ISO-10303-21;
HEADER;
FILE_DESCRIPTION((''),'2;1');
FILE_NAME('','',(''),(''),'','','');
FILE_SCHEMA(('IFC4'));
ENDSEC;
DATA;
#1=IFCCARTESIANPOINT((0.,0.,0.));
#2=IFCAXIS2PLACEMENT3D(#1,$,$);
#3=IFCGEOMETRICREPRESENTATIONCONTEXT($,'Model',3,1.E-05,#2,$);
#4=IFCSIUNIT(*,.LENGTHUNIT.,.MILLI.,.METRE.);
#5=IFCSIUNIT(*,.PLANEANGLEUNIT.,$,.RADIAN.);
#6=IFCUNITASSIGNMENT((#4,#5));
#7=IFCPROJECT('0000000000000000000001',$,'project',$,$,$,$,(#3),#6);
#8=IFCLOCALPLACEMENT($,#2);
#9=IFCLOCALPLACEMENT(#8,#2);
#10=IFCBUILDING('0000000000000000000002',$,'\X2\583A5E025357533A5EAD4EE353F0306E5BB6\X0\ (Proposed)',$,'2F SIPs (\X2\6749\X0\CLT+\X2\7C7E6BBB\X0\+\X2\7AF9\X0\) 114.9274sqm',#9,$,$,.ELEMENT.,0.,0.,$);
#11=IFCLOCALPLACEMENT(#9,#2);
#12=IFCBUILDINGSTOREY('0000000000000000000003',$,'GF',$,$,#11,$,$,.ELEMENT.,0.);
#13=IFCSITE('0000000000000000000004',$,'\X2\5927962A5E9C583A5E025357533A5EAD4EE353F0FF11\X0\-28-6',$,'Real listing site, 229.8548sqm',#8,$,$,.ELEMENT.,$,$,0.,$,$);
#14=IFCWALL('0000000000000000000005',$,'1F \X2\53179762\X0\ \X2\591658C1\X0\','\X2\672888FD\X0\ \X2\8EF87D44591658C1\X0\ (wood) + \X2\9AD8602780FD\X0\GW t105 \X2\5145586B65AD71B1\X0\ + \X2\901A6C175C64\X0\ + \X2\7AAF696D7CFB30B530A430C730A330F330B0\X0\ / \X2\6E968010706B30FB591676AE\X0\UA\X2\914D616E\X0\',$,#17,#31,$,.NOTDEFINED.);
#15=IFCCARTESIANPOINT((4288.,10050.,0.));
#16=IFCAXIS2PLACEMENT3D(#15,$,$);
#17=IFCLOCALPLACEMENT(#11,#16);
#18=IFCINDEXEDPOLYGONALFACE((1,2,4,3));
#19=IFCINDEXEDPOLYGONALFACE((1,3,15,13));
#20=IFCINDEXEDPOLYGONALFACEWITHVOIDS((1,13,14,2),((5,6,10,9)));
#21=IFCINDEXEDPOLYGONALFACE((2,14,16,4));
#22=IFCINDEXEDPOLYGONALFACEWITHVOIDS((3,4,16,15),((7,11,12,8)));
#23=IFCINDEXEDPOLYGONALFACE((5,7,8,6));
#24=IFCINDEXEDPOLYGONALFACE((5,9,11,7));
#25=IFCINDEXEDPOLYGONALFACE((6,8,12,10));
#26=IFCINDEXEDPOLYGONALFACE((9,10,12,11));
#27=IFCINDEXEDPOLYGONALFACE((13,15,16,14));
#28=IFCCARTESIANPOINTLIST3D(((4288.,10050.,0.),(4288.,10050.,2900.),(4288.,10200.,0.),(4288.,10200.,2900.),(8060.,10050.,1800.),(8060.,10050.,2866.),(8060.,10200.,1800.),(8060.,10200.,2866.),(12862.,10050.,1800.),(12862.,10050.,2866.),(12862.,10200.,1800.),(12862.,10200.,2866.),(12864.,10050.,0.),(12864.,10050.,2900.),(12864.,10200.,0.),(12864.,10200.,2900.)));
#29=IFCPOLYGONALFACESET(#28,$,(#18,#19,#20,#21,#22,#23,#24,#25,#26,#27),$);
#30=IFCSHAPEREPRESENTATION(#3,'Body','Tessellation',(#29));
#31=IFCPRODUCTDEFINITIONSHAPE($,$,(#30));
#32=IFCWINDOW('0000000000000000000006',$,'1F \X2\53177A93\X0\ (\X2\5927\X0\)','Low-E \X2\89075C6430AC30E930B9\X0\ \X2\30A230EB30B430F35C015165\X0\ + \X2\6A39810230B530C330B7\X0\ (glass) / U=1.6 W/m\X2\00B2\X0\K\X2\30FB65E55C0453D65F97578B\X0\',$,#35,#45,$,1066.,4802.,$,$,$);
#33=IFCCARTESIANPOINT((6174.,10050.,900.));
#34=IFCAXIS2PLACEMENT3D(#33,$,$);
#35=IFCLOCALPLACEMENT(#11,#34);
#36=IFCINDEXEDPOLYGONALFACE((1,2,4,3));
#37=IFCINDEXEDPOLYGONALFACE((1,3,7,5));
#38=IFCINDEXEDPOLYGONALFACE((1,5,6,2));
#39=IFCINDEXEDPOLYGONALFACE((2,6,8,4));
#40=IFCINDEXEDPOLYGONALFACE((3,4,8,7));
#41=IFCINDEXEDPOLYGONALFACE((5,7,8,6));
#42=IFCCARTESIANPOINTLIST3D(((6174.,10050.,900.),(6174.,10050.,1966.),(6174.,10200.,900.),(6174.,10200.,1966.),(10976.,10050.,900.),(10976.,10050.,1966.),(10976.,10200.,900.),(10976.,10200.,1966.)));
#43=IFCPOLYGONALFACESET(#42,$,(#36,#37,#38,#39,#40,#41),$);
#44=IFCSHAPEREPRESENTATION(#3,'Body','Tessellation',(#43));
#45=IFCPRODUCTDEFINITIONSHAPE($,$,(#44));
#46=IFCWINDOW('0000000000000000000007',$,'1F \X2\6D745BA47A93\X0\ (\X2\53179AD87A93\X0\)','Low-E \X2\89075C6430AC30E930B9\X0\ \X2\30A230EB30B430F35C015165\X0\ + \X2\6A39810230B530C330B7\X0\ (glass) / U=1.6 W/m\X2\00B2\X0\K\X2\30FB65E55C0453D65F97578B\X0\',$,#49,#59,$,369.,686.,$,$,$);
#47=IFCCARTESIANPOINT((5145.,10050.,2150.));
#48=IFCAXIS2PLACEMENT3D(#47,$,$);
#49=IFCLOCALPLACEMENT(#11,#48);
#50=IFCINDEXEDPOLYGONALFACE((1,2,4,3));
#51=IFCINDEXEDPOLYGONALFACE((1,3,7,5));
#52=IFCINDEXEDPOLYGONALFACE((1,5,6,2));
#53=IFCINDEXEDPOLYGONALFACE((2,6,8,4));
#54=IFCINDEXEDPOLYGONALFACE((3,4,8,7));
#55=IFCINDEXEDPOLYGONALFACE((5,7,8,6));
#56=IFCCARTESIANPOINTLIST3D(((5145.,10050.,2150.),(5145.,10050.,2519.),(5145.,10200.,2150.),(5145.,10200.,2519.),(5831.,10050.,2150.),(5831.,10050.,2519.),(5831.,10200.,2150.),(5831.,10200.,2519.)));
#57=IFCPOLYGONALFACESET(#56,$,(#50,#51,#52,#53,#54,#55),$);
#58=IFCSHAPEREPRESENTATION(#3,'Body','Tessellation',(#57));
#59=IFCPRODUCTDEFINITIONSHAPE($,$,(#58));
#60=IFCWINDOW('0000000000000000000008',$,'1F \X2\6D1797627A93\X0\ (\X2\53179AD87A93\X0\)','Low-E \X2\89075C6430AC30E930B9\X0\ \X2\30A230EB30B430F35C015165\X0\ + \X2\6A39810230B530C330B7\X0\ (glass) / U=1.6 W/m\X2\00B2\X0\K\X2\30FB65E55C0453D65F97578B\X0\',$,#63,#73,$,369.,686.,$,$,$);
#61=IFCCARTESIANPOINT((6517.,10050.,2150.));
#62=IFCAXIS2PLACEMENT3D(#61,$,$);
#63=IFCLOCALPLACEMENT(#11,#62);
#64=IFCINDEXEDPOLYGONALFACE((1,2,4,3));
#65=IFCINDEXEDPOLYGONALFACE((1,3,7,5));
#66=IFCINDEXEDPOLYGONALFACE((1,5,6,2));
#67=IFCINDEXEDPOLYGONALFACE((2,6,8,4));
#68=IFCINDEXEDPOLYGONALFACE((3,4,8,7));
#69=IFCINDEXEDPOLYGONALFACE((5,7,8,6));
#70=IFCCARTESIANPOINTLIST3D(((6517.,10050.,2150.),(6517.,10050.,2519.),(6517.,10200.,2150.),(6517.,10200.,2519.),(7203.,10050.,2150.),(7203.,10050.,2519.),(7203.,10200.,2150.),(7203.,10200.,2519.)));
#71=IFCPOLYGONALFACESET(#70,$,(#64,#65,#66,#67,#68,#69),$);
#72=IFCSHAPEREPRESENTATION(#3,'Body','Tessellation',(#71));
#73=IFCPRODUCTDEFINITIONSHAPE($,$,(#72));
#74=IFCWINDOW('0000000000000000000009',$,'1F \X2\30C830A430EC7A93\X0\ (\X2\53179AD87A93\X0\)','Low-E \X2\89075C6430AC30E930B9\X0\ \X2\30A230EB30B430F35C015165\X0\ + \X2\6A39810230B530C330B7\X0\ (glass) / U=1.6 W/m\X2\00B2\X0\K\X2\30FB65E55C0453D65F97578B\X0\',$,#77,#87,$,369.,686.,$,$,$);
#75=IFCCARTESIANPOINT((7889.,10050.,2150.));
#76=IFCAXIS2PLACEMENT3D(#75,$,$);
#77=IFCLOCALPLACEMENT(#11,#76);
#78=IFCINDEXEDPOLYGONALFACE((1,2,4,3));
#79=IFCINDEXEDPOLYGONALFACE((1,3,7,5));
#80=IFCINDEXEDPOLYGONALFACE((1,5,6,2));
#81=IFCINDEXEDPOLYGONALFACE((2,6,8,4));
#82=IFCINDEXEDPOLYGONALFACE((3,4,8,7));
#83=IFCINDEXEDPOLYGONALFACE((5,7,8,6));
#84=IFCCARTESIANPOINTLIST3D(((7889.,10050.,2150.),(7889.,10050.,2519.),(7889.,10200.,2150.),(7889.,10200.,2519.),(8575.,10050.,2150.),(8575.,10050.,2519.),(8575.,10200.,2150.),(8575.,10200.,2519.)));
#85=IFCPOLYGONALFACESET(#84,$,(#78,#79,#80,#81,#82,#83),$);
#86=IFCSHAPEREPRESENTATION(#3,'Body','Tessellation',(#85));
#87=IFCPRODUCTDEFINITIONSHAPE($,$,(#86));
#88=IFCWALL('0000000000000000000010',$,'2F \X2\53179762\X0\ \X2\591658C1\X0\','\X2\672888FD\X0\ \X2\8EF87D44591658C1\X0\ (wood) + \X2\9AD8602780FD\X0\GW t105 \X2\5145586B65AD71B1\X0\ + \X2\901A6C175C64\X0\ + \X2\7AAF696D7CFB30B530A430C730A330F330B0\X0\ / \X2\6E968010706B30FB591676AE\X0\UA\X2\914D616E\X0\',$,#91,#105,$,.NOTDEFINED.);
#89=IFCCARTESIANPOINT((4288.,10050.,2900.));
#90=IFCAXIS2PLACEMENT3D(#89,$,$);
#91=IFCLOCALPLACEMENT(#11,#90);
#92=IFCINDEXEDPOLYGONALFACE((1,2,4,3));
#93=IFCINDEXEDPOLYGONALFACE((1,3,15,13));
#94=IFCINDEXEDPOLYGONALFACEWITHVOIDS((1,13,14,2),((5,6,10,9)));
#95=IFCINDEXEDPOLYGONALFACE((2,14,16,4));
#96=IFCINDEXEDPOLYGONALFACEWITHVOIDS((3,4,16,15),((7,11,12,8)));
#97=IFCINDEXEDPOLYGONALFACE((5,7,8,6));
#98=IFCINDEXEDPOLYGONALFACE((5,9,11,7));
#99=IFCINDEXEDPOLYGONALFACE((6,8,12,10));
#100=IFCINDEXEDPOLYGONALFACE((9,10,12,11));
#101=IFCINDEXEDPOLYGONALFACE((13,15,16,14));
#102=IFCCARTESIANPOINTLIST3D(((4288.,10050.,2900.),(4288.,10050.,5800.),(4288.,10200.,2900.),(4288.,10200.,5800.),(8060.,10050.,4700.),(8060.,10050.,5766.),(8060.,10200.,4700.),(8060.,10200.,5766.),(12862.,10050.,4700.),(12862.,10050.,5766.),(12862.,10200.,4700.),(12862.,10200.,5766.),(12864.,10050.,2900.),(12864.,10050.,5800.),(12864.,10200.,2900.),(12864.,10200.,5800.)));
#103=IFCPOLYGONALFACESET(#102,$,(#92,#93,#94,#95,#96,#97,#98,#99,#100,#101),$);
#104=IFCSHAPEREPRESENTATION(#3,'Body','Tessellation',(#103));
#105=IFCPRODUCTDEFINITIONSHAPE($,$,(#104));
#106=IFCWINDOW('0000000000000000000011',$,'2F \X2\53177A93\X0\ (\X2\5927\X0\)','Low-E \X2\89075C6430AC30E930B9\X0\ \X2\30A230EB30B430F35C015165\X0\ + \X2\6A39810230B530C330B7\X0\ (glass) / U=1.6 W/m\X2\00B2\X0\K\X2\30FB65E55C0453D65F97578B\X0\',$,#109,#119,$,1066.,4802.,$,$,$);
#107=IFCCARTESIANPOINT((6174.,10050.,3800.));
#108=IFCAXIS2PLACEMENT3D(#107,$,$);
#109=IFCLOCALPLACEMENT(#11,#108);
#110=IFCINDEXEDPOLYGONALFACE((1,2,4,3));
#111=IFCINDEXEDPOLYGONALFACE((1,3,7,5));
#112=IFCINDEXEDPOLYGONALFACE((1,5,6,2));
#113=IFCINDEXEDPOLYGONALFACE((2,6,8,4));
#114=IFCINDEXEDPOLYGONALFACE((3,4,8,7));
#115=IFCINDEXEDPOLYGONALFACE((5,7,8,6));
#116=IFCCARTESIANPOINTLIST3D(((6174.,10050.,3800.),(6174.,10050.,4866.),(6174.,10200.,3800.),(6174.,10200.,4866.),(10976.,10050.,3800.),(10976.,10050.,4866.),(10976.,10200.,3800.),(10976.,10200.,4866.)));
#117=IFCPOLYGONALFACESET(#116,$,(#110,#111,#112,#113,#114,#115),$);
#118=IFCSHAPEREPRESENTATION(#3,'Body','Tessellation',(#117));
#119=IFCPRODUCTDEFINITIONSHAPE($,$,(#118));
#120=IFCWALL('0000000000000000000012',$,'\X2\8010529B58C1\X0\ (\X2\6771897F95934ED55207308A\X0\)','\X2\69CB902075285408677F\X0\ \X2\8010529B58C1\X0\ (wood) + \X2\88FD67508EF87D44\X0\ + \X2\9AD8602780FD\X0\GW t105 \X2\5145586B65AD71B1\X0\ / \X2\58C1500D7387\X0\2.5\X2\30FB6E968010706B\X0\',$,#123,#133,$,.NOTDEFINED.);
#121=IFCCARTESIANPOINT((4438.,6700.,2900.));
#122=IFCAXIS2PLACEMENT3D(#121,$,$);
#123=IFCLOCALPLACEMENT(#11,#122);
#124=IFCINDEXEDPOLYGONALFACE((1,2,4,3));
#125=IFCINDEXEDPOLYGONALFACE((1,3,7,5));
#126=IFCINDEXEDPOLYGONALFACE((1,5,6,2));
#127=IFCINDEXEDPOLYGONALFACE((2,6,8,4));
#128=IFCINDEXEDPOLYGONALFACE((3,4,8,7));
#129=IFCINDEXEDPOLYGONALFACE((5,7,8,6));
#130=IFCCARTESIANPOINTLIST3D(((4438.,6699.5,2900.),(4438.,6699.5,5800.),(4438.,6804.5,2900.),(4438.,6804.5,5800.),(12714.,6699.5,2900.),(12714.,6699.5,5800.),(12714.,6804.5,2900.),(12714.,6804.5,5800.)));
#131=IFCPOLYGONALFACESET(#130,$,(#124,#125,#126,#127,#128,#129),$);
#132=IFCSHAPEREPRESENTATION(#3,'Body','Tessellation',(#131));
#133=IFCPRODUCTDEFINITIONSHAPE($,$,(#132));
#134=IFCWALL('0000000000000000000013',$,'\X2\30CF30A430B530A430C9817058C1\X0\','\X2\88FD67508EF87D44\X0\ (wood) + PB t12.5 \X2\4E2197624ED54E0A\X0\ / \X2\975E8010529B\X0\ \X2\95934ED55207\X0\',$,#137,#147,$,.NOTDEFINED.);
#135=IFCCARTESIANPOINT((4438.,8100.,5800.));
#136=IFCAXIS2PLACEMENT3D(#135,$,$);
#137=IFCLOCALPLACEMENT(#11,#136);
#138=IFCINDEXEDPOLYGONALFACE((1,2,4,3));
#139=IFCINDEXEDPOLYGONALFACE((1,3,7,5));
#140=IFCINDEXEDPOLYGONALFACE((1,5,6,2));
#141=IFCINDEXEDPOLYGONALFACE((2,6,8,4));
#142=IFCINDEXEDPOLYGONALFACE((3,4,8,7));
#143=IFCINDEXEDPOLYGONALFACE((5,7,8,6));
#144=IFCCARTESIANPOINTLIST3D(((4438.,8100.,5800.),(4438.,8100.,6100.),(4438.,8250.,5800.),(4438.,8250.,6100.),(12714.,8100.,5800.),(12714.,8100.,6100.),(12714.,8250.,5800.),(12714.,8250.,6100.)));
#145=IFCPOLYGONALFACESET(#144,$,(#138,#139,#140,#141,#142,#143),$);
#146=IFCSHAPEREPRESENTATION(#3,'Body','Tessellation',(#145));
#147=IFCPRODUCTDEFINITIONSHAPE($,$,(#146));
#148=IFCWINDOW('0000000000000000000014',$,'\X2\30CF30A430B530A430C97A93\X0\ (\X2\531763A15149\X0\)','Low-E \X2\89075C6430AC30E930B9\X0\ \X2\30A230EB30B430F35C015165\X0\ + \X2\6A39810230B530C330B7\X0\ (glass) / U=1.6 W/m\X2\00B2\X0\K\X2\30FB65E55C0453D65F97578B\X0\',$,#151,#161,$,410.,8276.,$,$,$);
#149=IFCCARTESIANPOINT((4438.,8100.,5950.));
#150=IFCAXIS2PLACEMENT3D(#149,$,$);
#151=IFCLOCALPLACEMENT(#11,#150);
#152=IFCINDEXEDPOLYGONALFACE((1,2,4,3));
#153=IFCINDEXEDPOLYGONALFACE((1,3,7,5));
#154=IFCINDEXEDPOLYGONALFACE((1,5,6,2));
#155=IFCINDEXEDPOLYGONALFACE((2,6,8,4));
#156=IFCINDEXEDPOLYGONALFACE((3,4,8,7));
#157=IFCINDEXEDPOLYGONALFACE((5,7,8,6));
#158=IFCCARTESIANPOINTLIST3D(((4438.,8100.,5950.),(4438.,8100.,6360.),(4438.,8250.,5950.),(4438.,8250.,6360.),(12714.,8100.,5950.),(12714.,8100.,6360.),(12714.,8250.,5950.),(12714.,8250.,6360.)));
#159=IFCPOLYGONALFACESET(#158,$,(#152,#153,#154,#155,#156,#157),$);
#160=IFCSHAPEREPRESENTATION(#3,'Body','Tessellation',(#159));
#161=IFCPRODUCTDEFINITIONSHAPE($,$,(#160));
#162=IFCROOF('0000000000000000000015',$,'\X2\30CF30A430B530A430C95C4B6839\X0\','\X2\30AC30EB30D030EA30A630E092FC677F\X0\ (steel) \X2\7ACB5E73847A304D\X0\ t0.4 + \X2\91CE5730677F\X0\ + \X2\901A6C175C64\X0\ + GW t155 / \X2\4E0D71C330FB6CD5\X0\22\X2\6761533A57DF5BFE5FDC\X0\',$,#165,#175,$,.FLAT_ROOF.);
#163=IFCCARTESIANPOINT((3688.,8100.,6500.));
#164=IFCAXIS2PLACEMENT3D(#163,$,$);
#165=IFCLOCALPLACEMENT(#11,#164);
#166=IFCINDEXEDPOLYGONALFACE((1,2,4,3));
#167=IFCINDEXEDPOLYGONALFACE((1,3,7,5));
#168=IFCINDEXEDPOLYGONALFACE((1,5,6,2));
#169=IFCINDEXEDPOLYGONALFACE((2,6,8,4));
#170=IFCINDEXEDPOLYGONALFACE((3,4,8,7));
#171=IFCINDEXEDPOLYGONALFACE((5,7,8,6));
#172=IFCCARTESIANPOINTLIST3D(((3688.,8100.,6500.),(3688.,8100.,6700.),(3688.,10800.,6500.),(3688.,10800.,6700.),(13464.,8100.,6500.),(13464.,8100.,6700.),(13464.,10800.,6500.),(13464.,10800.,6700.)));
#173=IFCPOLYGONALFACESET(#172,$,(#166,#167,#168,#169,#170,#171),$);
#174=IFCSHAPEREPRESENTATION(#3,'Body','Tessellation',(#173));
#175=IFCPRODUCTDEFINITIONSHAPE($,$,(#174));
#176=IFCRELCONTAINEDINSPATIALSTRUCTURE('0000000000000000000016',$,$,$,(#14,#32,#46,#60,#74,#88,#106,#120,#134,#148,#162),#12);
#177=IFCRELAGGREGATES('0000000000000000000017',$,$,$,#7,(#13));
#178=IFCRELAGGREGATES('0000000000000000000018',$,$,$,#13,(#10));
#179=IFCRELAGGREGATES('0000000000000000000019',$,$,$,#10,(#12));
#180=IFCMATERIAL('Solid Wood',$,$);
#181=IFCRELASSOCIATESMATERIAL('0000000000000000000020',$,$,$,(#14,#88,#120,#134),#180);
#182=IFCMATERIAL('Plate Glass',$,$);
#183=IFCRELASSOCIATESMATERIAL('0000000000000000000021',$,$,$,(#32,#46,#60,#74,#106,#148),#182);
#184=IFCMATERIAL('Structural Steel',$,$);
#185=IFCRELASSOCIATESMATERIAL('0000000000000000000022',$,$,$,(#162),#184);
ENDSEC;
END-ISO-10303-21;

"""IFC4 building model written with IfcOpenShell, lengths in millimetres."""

from ifc_helpers import new_model, si_unit, frame, frame_2d, origin, place, context, project, spatial, rectangle, extrude, material, element, fill, save


model = new_model("IFC4")

# Units and contexts
model_context = context("Model", 3, precision=1e-05, world=origin())
ifc_project = project(units=[si_unit("LENGTHUNIT", "METRE", prefix="MILLI"), si_unit("PLANEANGLEUNIT", "RADIAN")], contexts=[model_context])

# Site, building, storey
site_placement = place(None, origin())
site = spatial("IfcSite", under=ifc_project, at=site_placement, Name="大阪府堺市南区庭代台１-28-6", ObjectType="Real listing site, 229.8548sqm", CompositionType="ELEMENT", RefElevation=0.0)
building_placement = place(site_placement, origin())
building = spatial("IfcBuilding", under=site, at=building_placement, Name="堺市南区庭代台の家 (Proposed)", ObjectType="2F SIPs (杉CLT+籾殻+竹) 114.9274sqm", CompositionType="ELEMENT", ElevationOfRefHeight=0.0, ElevationOfTerrain=0.0)
storey_placement = place(building_placement, origin())
storey = spatial("IfcBuildingStorey", under=building, at=storey_placement, Name="GF", CompositionType="ELEMENT", Elevation=0.0)

# Wall, openings, windows
ifc_material_1 = material(Name="Solid Wood")
wall_1_placement = place(storey_placement, frame((4288.0, 10050.0, 0.0)))
wall_1 = element("IfcWall", 1, at=wall_1_placement, inside=storey, material=ifc_material_1, Name="1F 北面 外壁", Description="木製 軸組外壁 (wood) + 高性能GW t105 充填断熱 + 通気層 + 窯業系サイディング / 準耐火・外皮UA配慮", PredefinedType="NOTDEFINED", context=model_context, shape_type="SweptSolid", body=[
    extrude(rectangle(XDim=8576.0, YDim=150.0, at=frame_2d((4288.0, 75.0))), frame((4288.0, 10050.0, 0.0)), (0.0, 0.0, 1.0), 2900.0),
])
opening_1_placement = place(storey_placement, frame((6174.0, 10050.0, 900.0)))
opening_1 = element("IfcOpeningElement", 2, at=opening_1_placement, cuts=wall_1, PredefinedType="NOTDEFINED", context=model_context, shape_type="SweptSolid", body=[
    extrude(rectangle(XDim=4802.0, YDim=150.0, at=frame_2d((2401.0, 75.0))), frame((6174.0, 10050.0, 900.0)), (0.0, 0.0, 1.0), 1066.0),
])
opening_2_placement = place(storey_placement, frame((5145.0, 10050.0, 2150.0)))
opening_2 = element("IfcOpeningElement", 3, at=opening_2_placement, cuts=wall_1, PredefinedType="NOTDEFINED", context=model_context, shape_type="SweptSolid", body=[
    extrude(rectangle(XDim=686.0, YDim=150.0, at=frame_2d((343.0, 75.0))), frame((5145.0, 10050.0, 2150.0)), (0.0, 0.0, 1.0), 369.0),
])
opening_3_placement = place(storey_placement, frame((6517.0, 10050.0, 2150.0)))
opening_3 = element("IfcOpeningElement", 4, at=opening_3_placement, cuts=wall_1, PredefinedType="NOTDEFINED", context=model_context, shape_type="SweptSolid", body=[
    extrude(rectangle(XDim=686.0, YDim=150.0, at=frame_2d((343.0, 75.0))), frame((6517.0, 10050.0, 2150.0)), (0.0, 0.0, 1.0), 369.0),
])
opening_4_placement = place(storey_placement, frame((7889.0, 10050.0, 2150.0)))
opening_4 = element("IfcOpeningElement", 5, at=opening_4_placement, cuts=wall_1, PredefinedType="NOTDEFINED", context=model_context, shape_type="SweptSolid", body=[
    extrude(rectangle(XDim=686.0, YDim=150.0, at=frame_2d((343.0, 75.0))), frame((7889.0, 10050.0, 2150.0)), (0.0, 0.0, 1.0), 369.0),
])
ifc_material_2 = material(Name="Plate Glass")
window_1_placement = place(storey_placement, frame((6174.0, 10050.0, 900.0)))
window_1 = element("IfcWindow", 6, at=window_1_placement, inside=storey, material=ifc_material_2, Name="1F 北窓 (大)", Description="Low-E 複層ガラス アルゴン封入 + 樹脂サッシ (glass) / U=1.6 W/m²K・日射取得型", OverallHeight=1066.0, OverallWidth=4802.0, context=model_context, shape_type="SweptSolid", body=[
    extrude(rectangle(XDim=4802.0, YDim=150.0, at=frame_2d((2401.0, 75.0))), frame((6174.0, 10050.0, 900.0)), (0.0, 0.0, 1.0), 1066.0),
])
fill(opening_1, window_1)
window_2_placement = place(storey_placement, frame((5145.0, 10050.0, 2150.0)))
window_2 = element("IfcWindow", 7, at=window_2_placement, inside=storey, material=ifc_material_2, Name="1F 浴室窓 (北高窓)", Description="Low-E 複層ガラス アルゴン封入 + 樹脂サッシ (glass) / U=1.6 W/m²K・日射取得型", OverallHeight=369.0, OverallWidth=686.0, context=model_context, shape_type="SweptSolid", body=[
    extrude(rectangle(XDim=686.0, YDim=150.0, at=frame_2d((343.0, 75.0))), frame((5145.0, 10050.0, 2150.0)), (0.0, 0.0, 1.0), 369.0),
])
fill(opening_2, window_2)
window_3_placement = place(storey_placement, frame((6517.0, 10050.0, 2150.0)))
window_3 = element("IfcWindow", 8, at=window_3_placement, inside=storey, material=ifc_material_2, Name="1F 洗面窓 (北高窓)", Description="Low-E 複層ガラス アルゴン封入 + 樹脂サッシ (glass) / U=1.6 W/m²K・日射取得型", OverallHeight=369.0, OverallWidth=686.0, context=model_context, shape_type="SweptSolid", body=[
    extrude(rectangle(XDim=686.0, YDim=150.0, at=frame_2d((343.0, 75.0))), frame((6517.0, 10050.0, 2150.0)), (0.0, 0.0, 1.0), 369.0),
])
fill(opening_3, window_3)
window_4_placement = place(storey_placement, frame((7889.0, 10050.0, 2150.0)))
window_4 = element("IfcWindow", 9, at=window_4_placement, inside=storey, material=ifc_material_2, Name="1F トイレ窓 (北高窓)", Description="Low-E 複層ガラス アルゴン封入 + 樹脂サッシ (glass) / U=1.6 W/m²K・日射取得型", OverallHeight=369.0, OverallWidth=686.0, context=model_context, shape_type="SweptSolid", body=[
    extrude(rectangle(XDim=686.0, YDim=150.0, at=frame_2d((343.0, 75.0))), frame((7889.0, 10050.0, 2150.0)), (0.0, 0.0, 1.0), 369.0),
])
fill(opening_4, window_4)

# Wall, opening, window
wall_2_placement = place(storey_placement, frame((4288.0, 10050.0, 2900.0)))
wall_2 = element("IfcWall", 10, at=wall_2_placement, inside=storey, material=ifc_material_1, Name="2F 北面 外壁", Description="木製 軸組外壁 (wood) + 高性能GW t105 充填断熱 + 通気層 + 窯業系サイディング / 準耐火・外皮UA配慮", PredefinedType="NOTDEFINED", context=model_context, shape_type="SweptSolid", body=[
    extrude(rectangle(XDim=8576.0, YDim=150.0, at=frame_2d((4288.0, 75.0))), frame((4288.0, 10050.0, 2900.0)), (0.0, 0.0, 1.0), 2900.0),
])
opening_5_placement = place(storey_placement, frame((6174.0, 10050.0, 3800.0)))
opening_5 = element("IfcOpeningElement", 11, at=opening_5_placement, cuts=wall_2, PredefinedType="NOTDEFINED", context=model_context, shape_type="SweptSolid", body=[
    extrude(rectangle(XDim=4802.0, YDim=150.0, at=frame_2d((2401.0, 75.0))), frame((6174.0, 10050.0, 3800.0)), (0.0, 0.0, 1.0), 1066.0),
])
window_5_placement = place(storey_placement, frame((6174.0, 10050.0, 3800.0)))
window_5 = element("IfcWindow", 12, at=window_5_placement, inside=storey, material=ifc_material_2, Name="2F 北窓 (大)", Description="Low-E 複層ガラス アルゴン封入 + 樹脂サッシ (glass) / U=1.6 W/m²K・日射取得型", OverallHeight=1066.0, OverallWidth=4802.0, context=model_context, shape_type="SweptSolid", body=[
    extrude(rectangle(XDim=4802.0, YDim=150.0, at=frame_2d((2401.0, 75.0))), frame((6174.0, 10050.0, 3800.0)), (0.0, 0.0, 1.0), 1066.0),
])
fill(opening_5, window_5)

# Wall
wall_3_placement = place(storey_placement, frame((4438.0, 6700.0, 2900.0)))
element("IfcWall", 13, at=wall_3_placement, inside=storey, material=ifc_material_1, Name="耐力壁 (東西間仕切り)", Description="構造用合板 耐力壁 (wood) + 製材軸組 + 高性能GW t105 充填断熱 / 壁倍率2.5・準耐火", PredefinedType="NOTDEFINED", context=model_context, shape_type="SweptSolid", body=[
    extrude(rectangle(XDim=8276.0, YDim=105.0, at=frame_2d((4138.0, 52.0))), frame((4438.0, 6700.0, 2900.0)), (0.0, 0.0, 1.0), 2900.0),
])

# Wall, opening, window
wall_4_placement = place(storey_placement, frame((4438.0, 8100.0, 5800.0)))
wall_4 = element("IfcWall", 14, at=wall_4_placement, inside=storey, material=ifc_material_1, Name="ハイサイド腰壁", Description="製材軸組 (wood) + PB t12.5 両面仕上 / 非耐力 間仕切", PredefinedType="NOTDEFINED", context=model_context, shape_type="SweptSolid", body=[
    extrude(rectangle(XDim=8276.0, YDim=150.0, at=frame_2d((4138.0, 75.0))), frame((4438.0, 8100.0, 5800.0)), (0.0, 0.0, 1.0), 700.0),
])
opening_6_placement = place(storey_placement, frame((4438.0, 8100.0, 5950.0)))
opening_6 = element("IfcOpeningElement", 15, at=opening_6_placement, cuts=wall_4, PredefinedType="NOTDEFINED", context=model_context, shape_type="SweptSolid", body=[
    extrude(rectangle(XDim=8276.0, YDim=150.0, at=frame_2d((4138.0, 75.0))), frame((4438.0, 8100.0, 5950.0)), (0.0, 0.0, 1.0), 410.0),
])
window_6_placement = place(storey_placement, frame((4438.0, 8100.0, 5950.0)))
window_6 = element("IfcWindow", 16, at=window_6_placement, inside=storey, material=ifc_material_2, Name="ハイサイド窓 (北採光)", Description="Low-E 複層ガラス アルゴン封入 + 樹脂サッシ (glass) / U=1.6 W/m²K・日射取得型", OverallHeight=410.0, OverallWidth=8276.0, context=model_context, shape_type="SweptSolid", body=[
    extrude(rectangle(XDim=8276.0, YDim=150.0, at=frame_2d((4138.0, 75.0))), frame((4438.0, 8100.0, 5950.0)), (0.0, 0.0, 1.0), 410.0),
])
fill(opening_6, window_6)

# Roof
ifc_material_3 = material(Name="Structural Steel")
roof_placement = place(storey_placement, frame((3688.0, 8100.0, 6500.0)))
element("IfcRoof", 17, at=roof_placement, inside=storey, material=ifc_material_3, Name="ハイサイド屋根", Description="ガルバリウム鋼板 (steel) 立平葺き t0.4 + 野地板 + 通気層 + GW t155 / 不燃・法22条区域対応", PredefinedType="FLAT_ROOF", context=model_context, shape_type="SweptSolid", body=[
    extrude(rectangle(XDim=9776.0, YDim=2700.0, at=frame_2d((4888.0, 1350.0))), frame((3688.0, 8100.0, 6500.0)), (0.0, 0.0, 1.0), 200.0),
])

save(model, "model.ifc")
